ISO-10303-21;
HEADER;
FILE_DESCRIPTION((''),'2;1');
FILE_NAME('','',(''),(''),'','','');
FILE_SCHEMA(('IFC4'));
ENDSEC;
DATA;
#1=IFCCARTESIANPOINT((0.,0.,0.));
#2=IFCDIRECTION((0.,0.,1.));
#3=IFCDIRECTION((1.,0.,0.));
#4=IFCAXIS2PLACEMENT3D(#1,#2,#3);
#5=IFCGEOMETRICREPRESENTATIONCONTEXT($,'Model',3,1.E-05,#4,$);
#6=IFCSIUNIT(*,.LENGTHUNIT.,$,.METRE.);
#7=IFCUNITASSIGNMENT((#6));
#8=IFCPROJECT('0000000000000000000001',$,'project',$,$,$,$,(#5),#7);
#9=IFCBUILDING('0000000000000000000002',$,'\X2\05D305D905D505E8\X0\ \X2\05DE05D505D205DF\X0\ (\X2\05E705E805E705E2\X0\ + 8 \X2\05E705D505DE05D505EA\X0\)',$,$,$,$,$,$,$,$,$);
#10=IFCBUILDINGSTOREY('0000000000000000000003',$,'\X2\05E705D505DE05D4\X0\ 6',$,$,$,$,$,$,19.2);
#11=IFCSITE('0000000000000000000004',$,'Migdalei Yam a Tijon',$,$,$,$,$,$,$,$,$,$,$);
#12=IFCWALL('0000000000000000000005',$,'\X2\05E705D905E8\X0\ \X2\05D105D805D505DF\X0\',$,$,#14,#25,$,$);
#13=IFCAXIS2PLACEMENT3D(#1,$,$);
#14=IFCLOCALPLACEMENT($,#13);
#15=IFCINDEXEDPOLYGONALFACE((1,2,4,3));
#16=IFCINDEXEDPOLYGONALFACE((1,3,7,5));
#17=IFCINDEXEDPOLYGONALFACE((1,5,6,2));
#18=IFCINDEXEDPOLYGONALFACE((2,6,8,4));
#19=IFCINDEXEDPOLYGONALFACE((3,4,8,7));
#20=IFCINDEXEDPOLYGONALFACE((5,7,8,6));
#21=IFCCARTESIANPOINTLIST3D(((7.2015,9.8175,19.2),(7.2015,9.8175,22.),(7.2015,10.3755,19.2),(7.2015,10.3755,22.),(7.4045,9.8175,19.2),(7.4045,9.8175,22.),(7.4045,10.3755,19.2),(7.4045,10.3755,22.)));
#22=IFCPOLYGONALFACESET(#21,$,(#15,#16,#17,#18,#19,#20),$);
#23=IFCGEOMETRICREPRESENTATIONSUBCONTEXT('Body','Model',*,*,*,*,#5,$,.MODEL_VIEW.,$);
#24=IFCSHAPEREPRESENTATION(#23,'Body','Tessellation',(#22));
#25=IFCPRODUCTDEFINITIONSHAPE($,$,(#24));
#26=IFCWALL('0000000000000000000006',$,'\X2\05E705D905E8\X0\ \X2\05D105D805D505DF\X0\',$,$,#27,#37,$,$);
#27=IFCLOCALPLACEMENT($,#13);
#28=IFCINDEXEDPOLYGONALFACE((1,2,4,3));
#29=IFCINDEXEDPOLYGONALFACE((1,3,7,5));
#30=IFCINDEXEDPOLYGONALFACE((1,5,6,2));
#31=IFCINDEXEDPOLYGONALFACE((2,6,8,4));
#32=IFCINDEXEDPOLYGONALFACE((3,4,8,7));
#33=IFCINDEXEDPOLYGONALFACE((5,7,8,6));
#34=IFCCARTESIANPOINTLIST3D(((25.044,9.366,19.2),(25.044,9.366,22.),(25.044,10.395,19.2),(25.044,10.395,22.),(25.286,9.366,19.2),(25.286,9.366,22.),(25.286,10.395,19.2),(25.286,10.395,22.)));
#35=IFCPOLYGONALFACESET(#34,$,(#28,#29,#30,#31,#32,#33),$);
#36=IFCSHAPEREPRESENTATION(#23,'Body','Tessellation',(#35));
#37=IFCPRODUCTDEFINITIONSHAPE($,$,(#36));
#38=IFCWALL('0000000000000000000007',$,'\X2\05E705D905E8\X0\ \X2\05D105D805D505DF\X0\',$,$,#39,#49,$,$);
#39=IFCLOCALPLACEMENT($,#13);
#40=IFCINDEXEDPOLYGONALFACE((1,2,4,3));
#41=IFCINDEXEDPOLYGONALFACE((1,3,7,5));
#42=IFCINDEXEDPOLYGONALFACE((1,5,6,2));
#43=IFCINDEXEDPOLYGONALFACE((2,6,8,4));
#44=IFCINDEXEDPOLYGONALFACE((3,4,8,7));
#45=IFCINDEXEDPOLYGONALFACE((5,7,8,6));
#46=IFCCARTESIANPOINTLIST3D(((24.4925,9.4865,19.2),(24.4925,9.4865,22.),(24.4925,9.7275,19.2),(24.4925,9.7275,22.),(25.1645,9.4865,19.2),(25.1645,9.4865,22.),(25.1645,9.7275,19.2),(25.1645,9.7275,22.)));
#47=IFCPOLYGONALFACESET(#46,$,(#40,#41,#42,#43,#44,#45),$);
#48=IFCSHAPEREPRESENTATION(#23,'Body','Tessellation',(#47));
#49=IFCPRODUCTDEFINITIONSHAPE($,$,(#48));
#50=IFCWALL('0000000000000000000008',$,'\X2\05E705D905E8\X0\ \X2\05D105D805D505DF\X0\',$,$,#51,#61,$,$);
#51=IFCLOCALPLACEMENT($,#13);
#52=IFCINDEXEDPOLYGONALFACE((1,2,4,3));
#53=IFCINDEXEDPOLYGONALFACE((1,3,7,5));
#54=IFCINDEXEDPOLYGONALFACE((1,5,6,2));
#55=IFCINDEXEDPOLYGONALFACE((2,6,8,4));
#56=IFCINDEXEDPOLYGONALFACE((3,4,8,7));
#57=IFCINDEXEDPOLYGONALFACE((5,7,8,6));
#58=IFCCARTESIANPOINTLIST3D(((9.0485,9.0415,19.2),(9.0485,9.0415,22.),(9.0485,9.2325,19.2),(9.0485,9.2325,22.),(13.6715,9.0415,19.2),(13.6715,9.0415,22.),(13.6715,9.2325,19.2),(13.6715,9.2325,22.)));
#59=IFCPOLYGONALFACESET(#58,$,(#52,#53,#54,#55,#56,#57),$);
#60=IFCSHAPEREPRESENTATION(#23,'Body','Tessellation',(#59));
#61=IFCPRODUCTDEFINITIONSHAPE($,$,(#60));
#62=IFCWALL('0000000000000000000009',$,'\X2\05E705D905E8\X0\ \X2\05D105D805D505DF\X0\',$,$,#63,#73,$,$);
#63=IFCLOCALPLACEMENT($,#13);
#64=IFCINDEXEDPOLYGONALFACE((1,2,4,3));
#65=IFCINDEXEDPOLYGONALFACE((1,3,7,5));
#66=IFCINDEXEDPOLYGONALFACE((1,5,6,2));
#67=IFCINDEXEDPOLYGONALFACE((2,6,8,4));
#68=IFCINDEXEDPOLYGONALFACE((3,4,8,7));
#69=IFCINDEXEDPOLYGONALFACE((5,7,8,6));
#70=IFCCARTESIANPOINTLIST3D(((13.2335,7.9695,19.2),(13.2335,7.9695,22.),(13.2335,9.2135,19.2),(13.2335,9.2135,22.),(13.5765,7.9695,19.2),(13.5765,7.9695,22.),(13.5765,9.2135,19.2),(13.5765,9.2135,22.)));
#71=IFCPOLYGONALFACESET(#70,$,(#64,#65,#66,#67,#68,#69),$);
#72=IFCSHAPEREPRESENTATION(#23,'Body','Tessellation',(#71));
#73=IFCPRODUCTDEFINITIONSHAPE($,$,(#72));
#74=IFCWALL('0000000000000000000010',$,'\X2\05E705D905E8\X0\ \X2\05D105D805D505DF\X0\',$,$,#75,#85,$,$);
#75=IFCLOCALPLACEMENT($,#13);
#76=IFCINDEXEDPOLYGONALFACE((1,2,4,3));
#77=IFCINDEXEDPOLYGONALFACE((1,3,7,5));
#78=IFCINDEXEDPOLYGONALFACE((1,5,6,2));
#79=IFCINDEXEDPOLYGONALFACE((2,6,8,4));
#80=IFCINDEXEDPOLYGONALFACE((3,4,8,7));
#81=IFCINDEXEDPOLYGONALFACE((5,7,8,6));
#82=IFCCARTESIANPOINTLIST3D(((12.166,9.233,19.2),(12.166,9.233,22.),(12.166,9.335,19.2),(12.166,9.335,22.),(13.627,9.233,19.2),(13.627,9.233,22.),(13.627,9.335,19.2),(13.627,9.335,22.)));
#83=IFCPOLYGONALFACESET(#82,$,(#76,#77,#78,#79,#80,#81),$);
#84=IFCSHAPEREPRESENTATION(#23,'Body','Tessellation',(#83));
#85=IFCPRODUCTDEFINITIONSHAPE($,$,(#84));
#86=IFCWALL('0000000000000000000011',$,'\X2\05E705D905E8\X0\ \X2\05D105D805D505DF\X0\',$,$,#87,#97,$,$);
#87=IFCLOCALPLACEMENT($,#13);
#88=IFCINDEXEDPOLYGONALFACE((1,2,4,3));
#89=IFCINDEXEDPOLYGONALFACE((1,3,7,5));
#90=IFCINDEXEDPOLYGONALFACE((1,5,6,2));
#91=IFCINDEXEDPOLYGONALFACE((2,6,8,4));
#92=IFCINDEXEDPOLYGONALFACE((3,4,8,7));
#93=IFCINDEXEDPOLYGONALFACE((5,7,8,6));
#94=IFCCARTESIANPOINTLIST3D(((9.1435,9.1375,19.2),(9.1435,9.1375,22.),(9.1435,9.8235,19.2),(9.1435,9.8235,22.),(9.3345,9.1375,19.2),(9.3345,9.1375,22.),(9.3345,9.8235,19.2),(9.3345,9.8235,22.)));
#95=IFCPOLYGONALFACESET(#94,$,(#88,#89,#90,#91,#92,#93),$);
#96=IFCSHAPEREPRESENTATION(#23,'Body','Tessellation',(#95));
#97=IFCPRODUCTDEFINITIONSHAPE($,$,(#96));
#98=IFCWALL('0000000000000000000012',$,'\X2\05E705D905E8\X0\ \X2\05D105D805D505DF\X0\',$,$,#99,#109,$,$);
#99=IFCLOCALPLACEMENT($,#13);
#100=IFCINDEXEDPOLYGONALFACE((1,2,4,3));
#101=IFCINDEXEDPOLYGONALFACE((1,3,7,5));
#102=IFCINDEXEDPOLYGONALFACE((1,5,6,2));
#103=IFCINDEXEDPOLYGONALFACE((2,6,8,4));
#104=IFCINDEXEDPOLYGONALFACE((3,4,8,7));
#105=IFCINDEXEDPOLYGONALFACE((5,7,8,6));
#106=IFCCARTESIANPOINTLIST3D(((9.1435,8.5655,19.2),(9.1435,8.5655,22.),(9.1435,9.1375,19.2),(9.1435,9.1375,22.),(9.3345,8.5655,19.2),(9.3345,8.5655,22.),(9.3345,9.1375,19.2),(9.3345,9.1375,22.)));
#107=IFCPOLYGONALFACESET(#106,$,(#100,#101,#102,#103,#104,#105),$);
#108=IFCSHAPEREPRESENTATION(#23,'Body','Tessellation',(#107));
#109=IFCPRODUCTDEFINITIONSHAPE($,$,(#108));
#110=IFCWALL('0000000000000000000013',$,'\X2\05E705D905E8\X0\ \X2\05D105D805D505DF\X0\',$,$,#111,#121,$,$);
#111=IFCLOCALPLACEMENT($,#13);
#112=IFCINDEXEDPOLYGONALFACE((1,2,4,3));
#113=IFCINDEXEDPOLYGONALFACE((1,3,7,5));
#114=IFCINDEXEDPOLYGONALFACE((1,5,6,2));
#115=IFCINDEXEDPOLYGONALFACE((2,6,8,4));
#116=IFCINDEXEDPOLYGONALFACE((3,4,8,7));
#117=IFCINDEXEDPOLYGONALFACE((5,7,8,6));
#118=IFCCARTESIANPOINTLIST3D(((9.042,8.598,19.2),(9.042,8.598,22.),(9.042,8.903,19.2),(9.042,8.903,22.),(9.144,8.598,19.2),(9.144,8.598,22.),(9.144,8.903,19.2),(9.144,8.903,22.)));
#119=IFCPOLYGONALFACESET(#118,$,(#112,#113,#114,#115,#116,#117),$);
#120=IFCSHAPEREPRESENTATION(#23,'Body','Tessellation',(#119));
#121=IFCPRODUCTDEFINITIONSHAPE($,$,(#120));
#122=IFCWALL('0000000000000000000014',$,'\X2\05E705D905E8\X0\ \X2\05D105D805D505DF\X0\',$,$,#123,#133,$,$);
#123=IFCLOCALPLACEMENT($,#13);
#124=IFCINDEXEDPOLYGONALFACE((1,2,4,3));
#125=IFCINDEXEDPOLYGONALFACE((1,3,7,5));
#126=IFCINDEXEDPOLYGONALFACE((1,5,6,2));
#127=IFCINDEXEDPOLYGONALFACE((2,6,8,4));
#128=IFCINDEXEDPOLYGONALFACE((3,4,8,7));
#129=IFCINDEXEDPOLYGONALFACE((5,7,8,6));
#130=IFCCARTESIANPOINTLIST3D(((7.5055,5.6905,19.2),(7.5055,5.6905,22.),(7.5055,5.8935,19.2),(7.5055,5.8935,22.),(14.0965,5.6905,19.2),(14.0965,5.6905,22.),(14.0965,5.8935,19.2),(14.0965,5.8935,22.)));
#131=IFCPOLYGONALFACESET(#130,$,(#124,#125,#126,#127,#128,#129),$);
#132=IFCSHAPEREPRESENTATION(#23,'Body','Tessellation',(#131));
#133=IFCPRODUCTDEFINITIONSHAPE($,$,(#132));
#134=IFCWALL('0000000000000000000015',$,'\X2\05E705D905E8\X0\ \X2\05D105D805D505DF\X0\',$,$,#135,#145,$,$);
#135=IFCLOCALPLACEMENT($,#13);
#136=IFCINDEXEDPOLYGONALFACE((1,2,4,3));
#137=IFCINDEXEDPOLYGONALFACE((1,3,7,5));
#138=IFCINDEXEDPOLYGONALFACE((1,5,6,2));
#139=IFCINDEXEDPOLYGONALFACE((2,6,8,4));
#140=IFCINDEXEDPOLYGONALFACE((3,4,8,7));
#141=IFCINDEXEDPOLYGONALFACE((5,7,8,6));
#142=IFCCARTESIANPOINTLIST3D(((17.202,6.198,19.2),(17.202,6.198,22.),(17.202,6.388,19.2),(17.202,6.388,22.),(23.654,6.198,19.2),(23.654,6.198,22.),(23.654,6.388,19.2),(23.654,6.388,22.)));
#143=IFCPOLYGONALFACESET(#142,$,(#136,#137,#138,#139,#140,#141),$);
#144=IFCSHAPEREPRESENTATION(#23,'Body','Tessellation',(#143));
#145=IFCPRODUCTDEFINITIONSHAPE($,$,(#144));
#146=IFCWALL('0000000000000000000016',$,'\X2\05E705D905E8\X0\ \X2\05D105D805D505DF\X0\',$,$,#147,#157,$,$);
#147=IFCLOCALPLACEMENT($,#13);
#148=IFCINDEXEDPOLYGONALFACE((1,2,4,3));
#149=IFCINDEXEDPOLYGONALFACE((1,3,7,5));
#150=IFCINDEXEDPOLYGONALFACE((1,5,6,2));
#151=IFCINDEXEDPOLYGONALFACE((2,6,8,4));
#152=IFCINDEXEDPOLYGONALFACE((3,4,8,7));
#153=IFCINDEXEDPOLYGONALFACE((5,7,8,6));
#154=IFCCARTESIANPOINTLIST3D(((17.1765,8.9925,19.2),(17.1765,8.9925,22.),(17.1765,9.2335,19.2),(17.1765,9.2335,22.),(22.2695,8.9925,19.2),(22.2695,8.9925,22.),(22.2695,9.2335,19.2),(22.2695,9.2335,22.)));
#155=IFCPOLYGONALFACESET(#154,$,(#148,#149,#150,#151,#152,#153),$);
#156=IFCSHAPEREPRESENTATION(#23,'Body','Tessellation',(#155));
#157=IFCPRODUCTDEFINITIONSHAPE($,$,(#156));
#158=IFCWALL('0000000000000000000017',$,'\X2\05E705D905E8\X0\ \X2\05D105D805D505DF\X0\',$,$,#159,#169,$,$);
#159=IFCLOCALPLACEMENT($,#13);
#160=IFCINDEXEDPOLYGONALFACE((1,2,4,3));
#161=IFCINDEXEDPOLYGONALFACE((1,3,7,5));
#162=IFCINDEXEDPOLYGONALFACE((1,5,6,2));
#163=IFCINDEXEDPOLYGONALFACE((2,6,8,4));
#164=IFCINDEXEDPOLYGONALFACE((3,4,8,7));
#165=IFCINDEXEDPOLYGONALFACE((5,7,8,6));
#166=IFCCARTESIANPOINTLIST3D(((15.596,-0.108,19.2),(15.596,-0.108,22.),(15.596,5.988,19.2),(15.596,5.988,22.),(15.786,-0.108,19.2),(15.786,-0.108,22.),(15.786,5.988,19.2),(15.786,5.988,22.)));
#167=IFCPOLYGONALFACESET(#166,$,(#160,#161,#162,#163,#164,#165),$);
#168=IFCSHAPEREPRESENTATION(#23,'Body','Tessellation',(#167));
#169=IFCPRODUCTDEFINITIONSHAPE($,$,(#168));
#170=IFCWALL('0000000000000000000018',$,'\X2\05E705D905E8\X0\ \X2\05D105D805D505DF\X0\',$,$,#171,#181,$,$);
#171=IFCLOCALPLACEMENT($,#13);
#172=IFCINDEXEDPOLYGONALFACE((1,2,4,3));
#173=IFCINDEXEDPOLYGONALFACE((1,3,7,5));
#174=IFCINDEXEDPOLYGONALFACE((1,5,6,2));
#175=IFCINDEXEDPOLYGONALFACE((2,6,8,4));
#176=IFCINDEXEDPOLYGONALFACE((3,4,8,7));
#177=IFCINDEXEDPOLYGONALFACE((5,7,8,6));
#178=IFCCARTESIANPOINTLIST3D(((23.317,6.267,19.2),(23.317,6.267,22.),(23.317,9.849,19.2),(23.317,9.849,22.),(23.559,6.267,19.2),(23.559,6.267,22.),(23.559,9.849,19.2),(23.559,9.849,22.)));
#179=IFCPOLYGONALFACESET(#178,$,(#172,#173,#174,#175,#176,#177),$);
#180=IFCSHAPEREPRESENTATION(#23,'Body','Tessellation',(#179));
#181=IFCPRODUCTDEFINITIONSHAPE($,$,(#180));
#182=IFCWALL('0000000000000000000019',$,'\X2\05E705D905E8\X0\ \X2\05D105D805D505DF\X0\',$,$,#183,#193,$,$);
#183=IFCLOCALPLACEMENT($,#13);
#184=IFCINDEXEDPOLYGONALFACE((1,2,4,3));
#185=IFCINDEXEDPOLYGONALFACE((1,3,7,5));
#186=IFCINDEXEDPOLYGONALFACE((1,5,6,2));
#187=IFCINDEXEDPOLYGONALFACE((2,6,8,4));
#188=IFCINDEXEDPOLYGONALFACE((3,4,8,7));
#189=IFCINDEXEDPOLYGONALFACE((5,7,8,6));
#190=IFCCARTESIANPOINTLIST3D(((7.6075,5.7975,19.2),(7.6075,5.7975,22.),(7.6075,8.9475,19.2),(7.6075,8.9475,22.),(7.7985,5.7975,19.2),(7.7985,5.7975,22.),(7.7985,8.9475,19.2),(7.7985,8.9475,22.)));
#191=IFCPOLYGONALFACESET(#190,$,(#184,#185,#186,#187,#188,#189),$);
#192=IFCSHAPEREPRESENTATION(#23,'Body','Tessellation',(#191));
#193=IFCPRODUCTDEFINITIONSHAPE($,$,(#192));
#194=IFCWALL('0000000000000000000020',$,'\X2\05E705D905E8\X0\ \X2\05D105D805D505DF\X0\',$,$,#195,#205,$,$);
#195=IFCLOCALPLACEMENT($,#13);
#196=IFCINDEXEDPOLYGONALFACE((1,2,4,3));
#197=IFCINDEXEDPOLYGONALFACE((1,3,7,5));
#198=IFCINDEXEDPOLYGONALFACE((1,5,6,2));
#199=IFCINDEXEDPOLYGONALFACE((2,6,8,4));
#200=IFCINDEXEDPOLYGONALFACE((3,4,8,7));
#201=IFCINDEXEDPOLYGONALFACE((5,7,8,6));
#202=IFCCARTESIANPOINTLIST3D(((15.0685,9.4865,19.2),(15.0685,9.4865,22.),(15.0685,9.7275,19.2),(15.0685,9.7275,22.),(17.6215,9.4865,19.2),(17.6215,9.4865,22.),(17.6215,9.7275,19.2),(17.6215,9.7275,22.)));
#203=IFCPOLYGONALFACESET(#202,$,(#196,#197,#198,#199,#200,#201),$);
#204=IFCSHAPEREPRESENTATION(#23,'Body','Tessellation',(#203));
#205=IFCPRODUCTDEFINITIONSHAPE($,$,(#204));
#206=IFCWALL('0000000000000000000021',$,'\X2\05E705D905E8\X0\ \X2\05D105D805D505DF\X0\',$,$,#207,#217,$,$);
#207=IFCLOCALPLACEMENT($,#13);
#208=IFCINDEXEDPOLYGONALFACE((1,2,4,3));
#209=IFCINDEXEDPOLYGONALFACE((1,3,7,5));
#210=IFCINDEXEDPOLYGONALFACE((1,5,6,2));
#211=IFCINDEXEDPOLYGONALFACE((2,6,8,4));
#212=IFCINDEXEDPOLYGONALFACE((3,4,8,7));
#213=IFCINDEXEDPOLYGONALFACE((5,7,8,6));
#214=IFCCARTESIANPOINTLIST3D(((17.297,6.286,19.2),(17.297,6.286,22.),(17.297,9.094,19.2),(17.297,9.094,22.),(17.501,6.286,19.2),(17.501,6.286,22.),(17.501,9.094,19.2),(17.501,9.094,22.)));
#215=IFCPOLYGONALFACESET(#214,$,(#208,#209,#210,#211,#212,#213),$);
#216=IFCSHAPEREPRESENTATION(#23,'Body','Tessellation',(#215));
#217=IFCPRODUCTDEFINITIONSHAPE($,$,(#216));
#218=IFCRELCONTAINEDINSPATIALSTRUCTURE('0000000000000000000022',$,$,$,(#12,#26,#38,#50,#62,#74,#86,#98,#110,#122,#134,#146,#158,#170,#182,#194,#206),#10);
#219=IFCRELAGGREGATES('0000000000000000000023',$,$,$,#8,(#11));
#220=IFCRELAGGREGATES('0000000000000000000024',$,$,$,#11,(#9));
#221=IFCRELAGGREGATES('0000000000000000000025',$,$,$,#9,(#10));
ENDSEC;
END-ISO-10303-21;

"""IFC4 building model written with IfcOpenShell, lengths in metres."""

from ifc_helpers import new_model, si_unit, frame, origin_with_axes, context, subcontext, project, spatial, line, indexed_curve, outline, extrude, element, save


model = new_model("IFC4")

# Units and contexts
model_context = context("Model", 3, precision=1e-05, world=origin_with_axes())
body_context = subcontext(model_context, "Body", "Model", "MODEL_VIEW")
ifc_project = project(units=[si_unit("LENGTHUNIT", "METRE")], contexts=[model_context])

# Site, building, storey
site = spatial("IfcSite", under=ifc_project, Name="Migdalei Yam a Tijon")
building = spatial("IfcBuilding", under=site, Name="דיור מוגן (קרקע + 8 קומות)")
storey = spatial("IfcBuildingStorey", under=building, Name="קומה 6", Elevation=19.2)

# Walls
element("IfcWall", 1, inside=storey, Name="קיר בטון", context=body_context, shape_type="SweptSolid", body=[
    extrude(outline(indexed_curve([(0.0, 0.0), (0.203, 0.0), (0.203, 0.558), (0.0, 0.558)], segments=[line(1, 2, 3, 4, 1)])), frame((7.2015, 9.8175, 19.2), z_axis=(0.0, 0.0, 1.0), x_axis=(1.0, 0.0, 0.0)), (0.0, 0.0, 1.0), 2.8),
])
element("IfcWall", 2, inside=storey, Name="קיר בטון", context=body_context, shape_type="SweptSolid", body=[
    extrude(outline(indexed_curve([(0.0, 0.0), (0.242, 0.0), (0.242, 1.029), (0.0, 1.029)], segments=[line(1, 2, 3, 4, 1)])), frame((25.044, 9.366, 19.2), z_axis=(0.0, 0.0, 1.0), x_axis=(1.0, 0.0, 0.0)), (0.0, 0.0, 1.0), 2.8),
])
element("IfcWall", 3, inside=storey, Name="קיר בטון", context=body_context, shape_type="SweptSolid", body=[
    extrude(outline(indexed_curve([(0.0, 0.0), (0.672, 0.0), (0.672, 0.241), (0.0, 0.241)], segments=[line(1, 2, 3, 4, 1)])), frame((24.4925, 9.4865, 19.2), z_axis=(0.0, 0.0, 1.0), x_axis=(1.0, 0.0, 0.0)), (0.0, 0.0, 1.0), 2.8),
])
element("IfcWall", 4, inside=storey, Name="קיר בטון", context=body_context, shape_type="SweptSolid", body=[
    extrude(outline(indexed_curve([(0.0, 0.0), (4.623, 0.0), (4.623, 0.191), (0.0, 0.191)], segments=[line(1, 2, 3, 4, 1)])), frame((9.0485, 9.0415, 19.2), z_axis=(0.0, 0.0, 1.0), x_axis=(1.0, 0.0, 0.0)), (0.0, 0.0, 1.0), 2.8),
])
element("IfcWall", 5, inside=storey, Name="קיר בטון", context=body_context, shape_type="SweptSolid", body=[
    extrude(outline(indexed_curve([(0.0, 0.0), (0.343, 0.0), (0.343, 1.244), (0.0, 1.244)], segments=[line(1, 2, 3, 4, 1)])), frame((13.2335, 7.9695, 19.2), z_axis=(0.0, 0.0, 1.0), x_axis=(1.0, 0.0, 0.0)), (0.0, 0.0, 1.0), 2.8),
])
element("IfcWall", 6, inside=storey, Name="קיר בטון", context=body_context, shape_type="SweptSolid", body=[
    extrude(outline(indexed_curve([(0.0, 0.0), (1.461, 0.0), (1.461, 0.102), (0.0, 0.102)], segments=[line(1, 2, 3, 4, 1)])), frame((12.166, 9.233, 19.2), z_axis=(0.0, 0.0, 1.0), x_axis=(1.0, 0.0, 0.0)), (0.0, 0.0, 1.0), 2.8),
])
element("IfcWall", 7, inside=storey, Name="קיר בטון", context=body_context, shape_type="SweptSolid", body=[
    extrude(outline(indexed_curve([(0.0, 0.0), (0.191, 0.0), (0.191, 0.686), (0.0, 0.686)], segments=[line(1, 2, 3, 4, 1)])), frame((9.1435, 9.1375, 19.2), z_axis=(0.0, 0.0, 1.0), x_axis=(1.0, 0.0, 0.0)), (0.0, 0.0, 1.0), 2.8),
])
element("IfcWall", 8, inside=storey, Name="קיר בטון", context=body_context, shape_type="SweptSolid", body=[
    extrude(outline(indexed_curve([(0.0, 0.0), (0.191, 0.0), (0.191, 0.572), (0.0, 0.572)], segments=[line(1, 2, 3, 4, 1)])), frame((9.1435, 8.5655, 19.2), z_axis=(0.0, 0.0, 1.0), x_axis=(1.0, 0.0, 0.0)), (0.0, 0.0, 1.0), 2.8),
])
element("IfcWall", 9, inside=storey, Name="קיר בטון", context=body_context, shape_type="SweptSolid", body=[
    extrude(outline(indexed_curve([(0.0, 0.0), (0.102, 0.0), (0.102, 0.305), (0.0, 0.305)], segments=[line(1, 2, 3, 4, 1)])), frame((9.042, 8.598, 19.2), z_axis=(0.0, 0.0, 1.0), x_axis=(1.0, 0.0, 0.0)), (0.0, 0.0, 1.0), 2.8),
])
element("IfcWall", 10, inside=storey, Name="קיר בטון", context=body_context, shape_type="SweptSolid", body=[
    extrude(outline(indexed_curve([(0.0, 0.0), (6.591, 0.0), (6.591, 0.203), (0.0, 0.203)], segments=[line(1, 2, 3, 4, 1)])), frame((7.5055, 5.6905, 19.2), z_axis=(0.0, 0.0, 1.0), x_axis=(1.0, 0.0, 0.0)), (0.0, 0.0, 1.0), 2.8),
])
element("IfcWall", 11, inside=storey, Name="קיר בטון", context=body_context, shape_type="SweptSolid", body=[
    extrude(outline(indexed_curve([(0.0, 0.0), (6.452, 0.0), (6.452, 0.19), (0.0, 0.19)], segments=[line(1, 2, 3, 4, 1)])), frame((17.202, 6.198, 19.2), z_axis=(0.0, 0.0, 1.0), x_axis=(1.0, 0.0, 0.0)), (0.0, 0.0, 1.0), 2.8),
])
element("IfcWall", 12, inside=storey, Name="קיר בטון", context=body_context, shape_type="SweptSolid", body=[
    extrude(outline(indexed_curve([(0.0, 0.0), (5.093, 0.0), (5.093, 0.241), (0.0, 0.241)], segments=[line(1, 2, 3, 4, 1)])), frame((17.1765, 8.9925, 19.2), z_axis=(0.0, 0.0, 1.0), x_axis=(1.0, 0.0, 0.0)), (0.0, 0.0, 1.0), 2.8),
])
element("IfcWall", 13, inside=storey, Name="קיר בטון", context=body_context, shape_type="SweptSolid", body=[
    extrude(outline(indexed_curve([(0.0, 0.0), (0.19, 0.0), (0.19, 6.096), (0.0, 6.096)], segments=[line(1, 2, 3, 4, 1)])), frame((15.596, -0.108, 19.2), z_axis=(0.0, 0.0, 1.0), x_axis=(1.0, 0.0, 0.0)), (0.0, 0.0, 1.0), 2.8),
])
element("IfcWall", 14, inside=storey, Name="קיר בטון", context=body_context, shape_type="SweptSolid", body=[
    extrude(outline(indexed_curve([(0.0, 0.0), (0.242, 0.0), (0.242, 3.582), (0.0, 3.582)], segments=[line(1, 2, 3, 4, 1)])), frame((23.317, 6.267, 19.2), z_axis=(0.0, 0.0, 1.0), x_axis=(1.0, 0.0, 0.0)), (0.0, 0.0, 1.0), 2.8),
])
element("IfcWall", 15, inside=storey, Name="קיר בטון", context=body_context, shape_type="SweptSolid", body=[
    extrude(outline(indexed_curve([(0.0, 0.0), (0.191, 0.0), (0.191, 3.15), (0.0, 3.15)], segments=[line(1, 2, 3, 4, 1)])), frame((7.6075, 5.7975, 19.2), z_axis=(0.0, 0.0, 1.0), x_axis=(1.0, 0.0, 0.0)), (0.0, 0.0, 1.0), 2.8),
])
element("IfcWall", 16, inside=storey, Name="קיר בטון", context=body_context, shape_type="SweptSolid", body=[
    extrude(outline(indexed_curve([(0.0, 0.0), (2.553, 0.0), (2.553, 0.241), (0.0, 0.241)], segments=[line(1, 2, 3, 4, 1)])), frame((15.0685, 9.4865, 19.2), z_axis=(0.0, 0.0, 1.0), x_axis=(1.0, 0.0, 0.0)), (0.0, 0.0, 1.0), 2.8),
])
element("IfcWall", 17, inside=storey, Name="קיר בטון", context=body_context, shape_type="SweptSolid", body=[
    extrude(outline(indexed_curve([(0.0, 0.0), (0.204, 0.0), (0.204, 2.808), (0.0, 2.808)], segments=[line(1, 2, 3, 4, 1)])), frame((17.297, 6.286, 19.2), z_axis=(0.0, 0.0, 1.0), x_axis=(1.0, 0.0, 0.0)), (0.0, 0.0, 1.0), 2.8),
])

save(model, "model.ifc")
